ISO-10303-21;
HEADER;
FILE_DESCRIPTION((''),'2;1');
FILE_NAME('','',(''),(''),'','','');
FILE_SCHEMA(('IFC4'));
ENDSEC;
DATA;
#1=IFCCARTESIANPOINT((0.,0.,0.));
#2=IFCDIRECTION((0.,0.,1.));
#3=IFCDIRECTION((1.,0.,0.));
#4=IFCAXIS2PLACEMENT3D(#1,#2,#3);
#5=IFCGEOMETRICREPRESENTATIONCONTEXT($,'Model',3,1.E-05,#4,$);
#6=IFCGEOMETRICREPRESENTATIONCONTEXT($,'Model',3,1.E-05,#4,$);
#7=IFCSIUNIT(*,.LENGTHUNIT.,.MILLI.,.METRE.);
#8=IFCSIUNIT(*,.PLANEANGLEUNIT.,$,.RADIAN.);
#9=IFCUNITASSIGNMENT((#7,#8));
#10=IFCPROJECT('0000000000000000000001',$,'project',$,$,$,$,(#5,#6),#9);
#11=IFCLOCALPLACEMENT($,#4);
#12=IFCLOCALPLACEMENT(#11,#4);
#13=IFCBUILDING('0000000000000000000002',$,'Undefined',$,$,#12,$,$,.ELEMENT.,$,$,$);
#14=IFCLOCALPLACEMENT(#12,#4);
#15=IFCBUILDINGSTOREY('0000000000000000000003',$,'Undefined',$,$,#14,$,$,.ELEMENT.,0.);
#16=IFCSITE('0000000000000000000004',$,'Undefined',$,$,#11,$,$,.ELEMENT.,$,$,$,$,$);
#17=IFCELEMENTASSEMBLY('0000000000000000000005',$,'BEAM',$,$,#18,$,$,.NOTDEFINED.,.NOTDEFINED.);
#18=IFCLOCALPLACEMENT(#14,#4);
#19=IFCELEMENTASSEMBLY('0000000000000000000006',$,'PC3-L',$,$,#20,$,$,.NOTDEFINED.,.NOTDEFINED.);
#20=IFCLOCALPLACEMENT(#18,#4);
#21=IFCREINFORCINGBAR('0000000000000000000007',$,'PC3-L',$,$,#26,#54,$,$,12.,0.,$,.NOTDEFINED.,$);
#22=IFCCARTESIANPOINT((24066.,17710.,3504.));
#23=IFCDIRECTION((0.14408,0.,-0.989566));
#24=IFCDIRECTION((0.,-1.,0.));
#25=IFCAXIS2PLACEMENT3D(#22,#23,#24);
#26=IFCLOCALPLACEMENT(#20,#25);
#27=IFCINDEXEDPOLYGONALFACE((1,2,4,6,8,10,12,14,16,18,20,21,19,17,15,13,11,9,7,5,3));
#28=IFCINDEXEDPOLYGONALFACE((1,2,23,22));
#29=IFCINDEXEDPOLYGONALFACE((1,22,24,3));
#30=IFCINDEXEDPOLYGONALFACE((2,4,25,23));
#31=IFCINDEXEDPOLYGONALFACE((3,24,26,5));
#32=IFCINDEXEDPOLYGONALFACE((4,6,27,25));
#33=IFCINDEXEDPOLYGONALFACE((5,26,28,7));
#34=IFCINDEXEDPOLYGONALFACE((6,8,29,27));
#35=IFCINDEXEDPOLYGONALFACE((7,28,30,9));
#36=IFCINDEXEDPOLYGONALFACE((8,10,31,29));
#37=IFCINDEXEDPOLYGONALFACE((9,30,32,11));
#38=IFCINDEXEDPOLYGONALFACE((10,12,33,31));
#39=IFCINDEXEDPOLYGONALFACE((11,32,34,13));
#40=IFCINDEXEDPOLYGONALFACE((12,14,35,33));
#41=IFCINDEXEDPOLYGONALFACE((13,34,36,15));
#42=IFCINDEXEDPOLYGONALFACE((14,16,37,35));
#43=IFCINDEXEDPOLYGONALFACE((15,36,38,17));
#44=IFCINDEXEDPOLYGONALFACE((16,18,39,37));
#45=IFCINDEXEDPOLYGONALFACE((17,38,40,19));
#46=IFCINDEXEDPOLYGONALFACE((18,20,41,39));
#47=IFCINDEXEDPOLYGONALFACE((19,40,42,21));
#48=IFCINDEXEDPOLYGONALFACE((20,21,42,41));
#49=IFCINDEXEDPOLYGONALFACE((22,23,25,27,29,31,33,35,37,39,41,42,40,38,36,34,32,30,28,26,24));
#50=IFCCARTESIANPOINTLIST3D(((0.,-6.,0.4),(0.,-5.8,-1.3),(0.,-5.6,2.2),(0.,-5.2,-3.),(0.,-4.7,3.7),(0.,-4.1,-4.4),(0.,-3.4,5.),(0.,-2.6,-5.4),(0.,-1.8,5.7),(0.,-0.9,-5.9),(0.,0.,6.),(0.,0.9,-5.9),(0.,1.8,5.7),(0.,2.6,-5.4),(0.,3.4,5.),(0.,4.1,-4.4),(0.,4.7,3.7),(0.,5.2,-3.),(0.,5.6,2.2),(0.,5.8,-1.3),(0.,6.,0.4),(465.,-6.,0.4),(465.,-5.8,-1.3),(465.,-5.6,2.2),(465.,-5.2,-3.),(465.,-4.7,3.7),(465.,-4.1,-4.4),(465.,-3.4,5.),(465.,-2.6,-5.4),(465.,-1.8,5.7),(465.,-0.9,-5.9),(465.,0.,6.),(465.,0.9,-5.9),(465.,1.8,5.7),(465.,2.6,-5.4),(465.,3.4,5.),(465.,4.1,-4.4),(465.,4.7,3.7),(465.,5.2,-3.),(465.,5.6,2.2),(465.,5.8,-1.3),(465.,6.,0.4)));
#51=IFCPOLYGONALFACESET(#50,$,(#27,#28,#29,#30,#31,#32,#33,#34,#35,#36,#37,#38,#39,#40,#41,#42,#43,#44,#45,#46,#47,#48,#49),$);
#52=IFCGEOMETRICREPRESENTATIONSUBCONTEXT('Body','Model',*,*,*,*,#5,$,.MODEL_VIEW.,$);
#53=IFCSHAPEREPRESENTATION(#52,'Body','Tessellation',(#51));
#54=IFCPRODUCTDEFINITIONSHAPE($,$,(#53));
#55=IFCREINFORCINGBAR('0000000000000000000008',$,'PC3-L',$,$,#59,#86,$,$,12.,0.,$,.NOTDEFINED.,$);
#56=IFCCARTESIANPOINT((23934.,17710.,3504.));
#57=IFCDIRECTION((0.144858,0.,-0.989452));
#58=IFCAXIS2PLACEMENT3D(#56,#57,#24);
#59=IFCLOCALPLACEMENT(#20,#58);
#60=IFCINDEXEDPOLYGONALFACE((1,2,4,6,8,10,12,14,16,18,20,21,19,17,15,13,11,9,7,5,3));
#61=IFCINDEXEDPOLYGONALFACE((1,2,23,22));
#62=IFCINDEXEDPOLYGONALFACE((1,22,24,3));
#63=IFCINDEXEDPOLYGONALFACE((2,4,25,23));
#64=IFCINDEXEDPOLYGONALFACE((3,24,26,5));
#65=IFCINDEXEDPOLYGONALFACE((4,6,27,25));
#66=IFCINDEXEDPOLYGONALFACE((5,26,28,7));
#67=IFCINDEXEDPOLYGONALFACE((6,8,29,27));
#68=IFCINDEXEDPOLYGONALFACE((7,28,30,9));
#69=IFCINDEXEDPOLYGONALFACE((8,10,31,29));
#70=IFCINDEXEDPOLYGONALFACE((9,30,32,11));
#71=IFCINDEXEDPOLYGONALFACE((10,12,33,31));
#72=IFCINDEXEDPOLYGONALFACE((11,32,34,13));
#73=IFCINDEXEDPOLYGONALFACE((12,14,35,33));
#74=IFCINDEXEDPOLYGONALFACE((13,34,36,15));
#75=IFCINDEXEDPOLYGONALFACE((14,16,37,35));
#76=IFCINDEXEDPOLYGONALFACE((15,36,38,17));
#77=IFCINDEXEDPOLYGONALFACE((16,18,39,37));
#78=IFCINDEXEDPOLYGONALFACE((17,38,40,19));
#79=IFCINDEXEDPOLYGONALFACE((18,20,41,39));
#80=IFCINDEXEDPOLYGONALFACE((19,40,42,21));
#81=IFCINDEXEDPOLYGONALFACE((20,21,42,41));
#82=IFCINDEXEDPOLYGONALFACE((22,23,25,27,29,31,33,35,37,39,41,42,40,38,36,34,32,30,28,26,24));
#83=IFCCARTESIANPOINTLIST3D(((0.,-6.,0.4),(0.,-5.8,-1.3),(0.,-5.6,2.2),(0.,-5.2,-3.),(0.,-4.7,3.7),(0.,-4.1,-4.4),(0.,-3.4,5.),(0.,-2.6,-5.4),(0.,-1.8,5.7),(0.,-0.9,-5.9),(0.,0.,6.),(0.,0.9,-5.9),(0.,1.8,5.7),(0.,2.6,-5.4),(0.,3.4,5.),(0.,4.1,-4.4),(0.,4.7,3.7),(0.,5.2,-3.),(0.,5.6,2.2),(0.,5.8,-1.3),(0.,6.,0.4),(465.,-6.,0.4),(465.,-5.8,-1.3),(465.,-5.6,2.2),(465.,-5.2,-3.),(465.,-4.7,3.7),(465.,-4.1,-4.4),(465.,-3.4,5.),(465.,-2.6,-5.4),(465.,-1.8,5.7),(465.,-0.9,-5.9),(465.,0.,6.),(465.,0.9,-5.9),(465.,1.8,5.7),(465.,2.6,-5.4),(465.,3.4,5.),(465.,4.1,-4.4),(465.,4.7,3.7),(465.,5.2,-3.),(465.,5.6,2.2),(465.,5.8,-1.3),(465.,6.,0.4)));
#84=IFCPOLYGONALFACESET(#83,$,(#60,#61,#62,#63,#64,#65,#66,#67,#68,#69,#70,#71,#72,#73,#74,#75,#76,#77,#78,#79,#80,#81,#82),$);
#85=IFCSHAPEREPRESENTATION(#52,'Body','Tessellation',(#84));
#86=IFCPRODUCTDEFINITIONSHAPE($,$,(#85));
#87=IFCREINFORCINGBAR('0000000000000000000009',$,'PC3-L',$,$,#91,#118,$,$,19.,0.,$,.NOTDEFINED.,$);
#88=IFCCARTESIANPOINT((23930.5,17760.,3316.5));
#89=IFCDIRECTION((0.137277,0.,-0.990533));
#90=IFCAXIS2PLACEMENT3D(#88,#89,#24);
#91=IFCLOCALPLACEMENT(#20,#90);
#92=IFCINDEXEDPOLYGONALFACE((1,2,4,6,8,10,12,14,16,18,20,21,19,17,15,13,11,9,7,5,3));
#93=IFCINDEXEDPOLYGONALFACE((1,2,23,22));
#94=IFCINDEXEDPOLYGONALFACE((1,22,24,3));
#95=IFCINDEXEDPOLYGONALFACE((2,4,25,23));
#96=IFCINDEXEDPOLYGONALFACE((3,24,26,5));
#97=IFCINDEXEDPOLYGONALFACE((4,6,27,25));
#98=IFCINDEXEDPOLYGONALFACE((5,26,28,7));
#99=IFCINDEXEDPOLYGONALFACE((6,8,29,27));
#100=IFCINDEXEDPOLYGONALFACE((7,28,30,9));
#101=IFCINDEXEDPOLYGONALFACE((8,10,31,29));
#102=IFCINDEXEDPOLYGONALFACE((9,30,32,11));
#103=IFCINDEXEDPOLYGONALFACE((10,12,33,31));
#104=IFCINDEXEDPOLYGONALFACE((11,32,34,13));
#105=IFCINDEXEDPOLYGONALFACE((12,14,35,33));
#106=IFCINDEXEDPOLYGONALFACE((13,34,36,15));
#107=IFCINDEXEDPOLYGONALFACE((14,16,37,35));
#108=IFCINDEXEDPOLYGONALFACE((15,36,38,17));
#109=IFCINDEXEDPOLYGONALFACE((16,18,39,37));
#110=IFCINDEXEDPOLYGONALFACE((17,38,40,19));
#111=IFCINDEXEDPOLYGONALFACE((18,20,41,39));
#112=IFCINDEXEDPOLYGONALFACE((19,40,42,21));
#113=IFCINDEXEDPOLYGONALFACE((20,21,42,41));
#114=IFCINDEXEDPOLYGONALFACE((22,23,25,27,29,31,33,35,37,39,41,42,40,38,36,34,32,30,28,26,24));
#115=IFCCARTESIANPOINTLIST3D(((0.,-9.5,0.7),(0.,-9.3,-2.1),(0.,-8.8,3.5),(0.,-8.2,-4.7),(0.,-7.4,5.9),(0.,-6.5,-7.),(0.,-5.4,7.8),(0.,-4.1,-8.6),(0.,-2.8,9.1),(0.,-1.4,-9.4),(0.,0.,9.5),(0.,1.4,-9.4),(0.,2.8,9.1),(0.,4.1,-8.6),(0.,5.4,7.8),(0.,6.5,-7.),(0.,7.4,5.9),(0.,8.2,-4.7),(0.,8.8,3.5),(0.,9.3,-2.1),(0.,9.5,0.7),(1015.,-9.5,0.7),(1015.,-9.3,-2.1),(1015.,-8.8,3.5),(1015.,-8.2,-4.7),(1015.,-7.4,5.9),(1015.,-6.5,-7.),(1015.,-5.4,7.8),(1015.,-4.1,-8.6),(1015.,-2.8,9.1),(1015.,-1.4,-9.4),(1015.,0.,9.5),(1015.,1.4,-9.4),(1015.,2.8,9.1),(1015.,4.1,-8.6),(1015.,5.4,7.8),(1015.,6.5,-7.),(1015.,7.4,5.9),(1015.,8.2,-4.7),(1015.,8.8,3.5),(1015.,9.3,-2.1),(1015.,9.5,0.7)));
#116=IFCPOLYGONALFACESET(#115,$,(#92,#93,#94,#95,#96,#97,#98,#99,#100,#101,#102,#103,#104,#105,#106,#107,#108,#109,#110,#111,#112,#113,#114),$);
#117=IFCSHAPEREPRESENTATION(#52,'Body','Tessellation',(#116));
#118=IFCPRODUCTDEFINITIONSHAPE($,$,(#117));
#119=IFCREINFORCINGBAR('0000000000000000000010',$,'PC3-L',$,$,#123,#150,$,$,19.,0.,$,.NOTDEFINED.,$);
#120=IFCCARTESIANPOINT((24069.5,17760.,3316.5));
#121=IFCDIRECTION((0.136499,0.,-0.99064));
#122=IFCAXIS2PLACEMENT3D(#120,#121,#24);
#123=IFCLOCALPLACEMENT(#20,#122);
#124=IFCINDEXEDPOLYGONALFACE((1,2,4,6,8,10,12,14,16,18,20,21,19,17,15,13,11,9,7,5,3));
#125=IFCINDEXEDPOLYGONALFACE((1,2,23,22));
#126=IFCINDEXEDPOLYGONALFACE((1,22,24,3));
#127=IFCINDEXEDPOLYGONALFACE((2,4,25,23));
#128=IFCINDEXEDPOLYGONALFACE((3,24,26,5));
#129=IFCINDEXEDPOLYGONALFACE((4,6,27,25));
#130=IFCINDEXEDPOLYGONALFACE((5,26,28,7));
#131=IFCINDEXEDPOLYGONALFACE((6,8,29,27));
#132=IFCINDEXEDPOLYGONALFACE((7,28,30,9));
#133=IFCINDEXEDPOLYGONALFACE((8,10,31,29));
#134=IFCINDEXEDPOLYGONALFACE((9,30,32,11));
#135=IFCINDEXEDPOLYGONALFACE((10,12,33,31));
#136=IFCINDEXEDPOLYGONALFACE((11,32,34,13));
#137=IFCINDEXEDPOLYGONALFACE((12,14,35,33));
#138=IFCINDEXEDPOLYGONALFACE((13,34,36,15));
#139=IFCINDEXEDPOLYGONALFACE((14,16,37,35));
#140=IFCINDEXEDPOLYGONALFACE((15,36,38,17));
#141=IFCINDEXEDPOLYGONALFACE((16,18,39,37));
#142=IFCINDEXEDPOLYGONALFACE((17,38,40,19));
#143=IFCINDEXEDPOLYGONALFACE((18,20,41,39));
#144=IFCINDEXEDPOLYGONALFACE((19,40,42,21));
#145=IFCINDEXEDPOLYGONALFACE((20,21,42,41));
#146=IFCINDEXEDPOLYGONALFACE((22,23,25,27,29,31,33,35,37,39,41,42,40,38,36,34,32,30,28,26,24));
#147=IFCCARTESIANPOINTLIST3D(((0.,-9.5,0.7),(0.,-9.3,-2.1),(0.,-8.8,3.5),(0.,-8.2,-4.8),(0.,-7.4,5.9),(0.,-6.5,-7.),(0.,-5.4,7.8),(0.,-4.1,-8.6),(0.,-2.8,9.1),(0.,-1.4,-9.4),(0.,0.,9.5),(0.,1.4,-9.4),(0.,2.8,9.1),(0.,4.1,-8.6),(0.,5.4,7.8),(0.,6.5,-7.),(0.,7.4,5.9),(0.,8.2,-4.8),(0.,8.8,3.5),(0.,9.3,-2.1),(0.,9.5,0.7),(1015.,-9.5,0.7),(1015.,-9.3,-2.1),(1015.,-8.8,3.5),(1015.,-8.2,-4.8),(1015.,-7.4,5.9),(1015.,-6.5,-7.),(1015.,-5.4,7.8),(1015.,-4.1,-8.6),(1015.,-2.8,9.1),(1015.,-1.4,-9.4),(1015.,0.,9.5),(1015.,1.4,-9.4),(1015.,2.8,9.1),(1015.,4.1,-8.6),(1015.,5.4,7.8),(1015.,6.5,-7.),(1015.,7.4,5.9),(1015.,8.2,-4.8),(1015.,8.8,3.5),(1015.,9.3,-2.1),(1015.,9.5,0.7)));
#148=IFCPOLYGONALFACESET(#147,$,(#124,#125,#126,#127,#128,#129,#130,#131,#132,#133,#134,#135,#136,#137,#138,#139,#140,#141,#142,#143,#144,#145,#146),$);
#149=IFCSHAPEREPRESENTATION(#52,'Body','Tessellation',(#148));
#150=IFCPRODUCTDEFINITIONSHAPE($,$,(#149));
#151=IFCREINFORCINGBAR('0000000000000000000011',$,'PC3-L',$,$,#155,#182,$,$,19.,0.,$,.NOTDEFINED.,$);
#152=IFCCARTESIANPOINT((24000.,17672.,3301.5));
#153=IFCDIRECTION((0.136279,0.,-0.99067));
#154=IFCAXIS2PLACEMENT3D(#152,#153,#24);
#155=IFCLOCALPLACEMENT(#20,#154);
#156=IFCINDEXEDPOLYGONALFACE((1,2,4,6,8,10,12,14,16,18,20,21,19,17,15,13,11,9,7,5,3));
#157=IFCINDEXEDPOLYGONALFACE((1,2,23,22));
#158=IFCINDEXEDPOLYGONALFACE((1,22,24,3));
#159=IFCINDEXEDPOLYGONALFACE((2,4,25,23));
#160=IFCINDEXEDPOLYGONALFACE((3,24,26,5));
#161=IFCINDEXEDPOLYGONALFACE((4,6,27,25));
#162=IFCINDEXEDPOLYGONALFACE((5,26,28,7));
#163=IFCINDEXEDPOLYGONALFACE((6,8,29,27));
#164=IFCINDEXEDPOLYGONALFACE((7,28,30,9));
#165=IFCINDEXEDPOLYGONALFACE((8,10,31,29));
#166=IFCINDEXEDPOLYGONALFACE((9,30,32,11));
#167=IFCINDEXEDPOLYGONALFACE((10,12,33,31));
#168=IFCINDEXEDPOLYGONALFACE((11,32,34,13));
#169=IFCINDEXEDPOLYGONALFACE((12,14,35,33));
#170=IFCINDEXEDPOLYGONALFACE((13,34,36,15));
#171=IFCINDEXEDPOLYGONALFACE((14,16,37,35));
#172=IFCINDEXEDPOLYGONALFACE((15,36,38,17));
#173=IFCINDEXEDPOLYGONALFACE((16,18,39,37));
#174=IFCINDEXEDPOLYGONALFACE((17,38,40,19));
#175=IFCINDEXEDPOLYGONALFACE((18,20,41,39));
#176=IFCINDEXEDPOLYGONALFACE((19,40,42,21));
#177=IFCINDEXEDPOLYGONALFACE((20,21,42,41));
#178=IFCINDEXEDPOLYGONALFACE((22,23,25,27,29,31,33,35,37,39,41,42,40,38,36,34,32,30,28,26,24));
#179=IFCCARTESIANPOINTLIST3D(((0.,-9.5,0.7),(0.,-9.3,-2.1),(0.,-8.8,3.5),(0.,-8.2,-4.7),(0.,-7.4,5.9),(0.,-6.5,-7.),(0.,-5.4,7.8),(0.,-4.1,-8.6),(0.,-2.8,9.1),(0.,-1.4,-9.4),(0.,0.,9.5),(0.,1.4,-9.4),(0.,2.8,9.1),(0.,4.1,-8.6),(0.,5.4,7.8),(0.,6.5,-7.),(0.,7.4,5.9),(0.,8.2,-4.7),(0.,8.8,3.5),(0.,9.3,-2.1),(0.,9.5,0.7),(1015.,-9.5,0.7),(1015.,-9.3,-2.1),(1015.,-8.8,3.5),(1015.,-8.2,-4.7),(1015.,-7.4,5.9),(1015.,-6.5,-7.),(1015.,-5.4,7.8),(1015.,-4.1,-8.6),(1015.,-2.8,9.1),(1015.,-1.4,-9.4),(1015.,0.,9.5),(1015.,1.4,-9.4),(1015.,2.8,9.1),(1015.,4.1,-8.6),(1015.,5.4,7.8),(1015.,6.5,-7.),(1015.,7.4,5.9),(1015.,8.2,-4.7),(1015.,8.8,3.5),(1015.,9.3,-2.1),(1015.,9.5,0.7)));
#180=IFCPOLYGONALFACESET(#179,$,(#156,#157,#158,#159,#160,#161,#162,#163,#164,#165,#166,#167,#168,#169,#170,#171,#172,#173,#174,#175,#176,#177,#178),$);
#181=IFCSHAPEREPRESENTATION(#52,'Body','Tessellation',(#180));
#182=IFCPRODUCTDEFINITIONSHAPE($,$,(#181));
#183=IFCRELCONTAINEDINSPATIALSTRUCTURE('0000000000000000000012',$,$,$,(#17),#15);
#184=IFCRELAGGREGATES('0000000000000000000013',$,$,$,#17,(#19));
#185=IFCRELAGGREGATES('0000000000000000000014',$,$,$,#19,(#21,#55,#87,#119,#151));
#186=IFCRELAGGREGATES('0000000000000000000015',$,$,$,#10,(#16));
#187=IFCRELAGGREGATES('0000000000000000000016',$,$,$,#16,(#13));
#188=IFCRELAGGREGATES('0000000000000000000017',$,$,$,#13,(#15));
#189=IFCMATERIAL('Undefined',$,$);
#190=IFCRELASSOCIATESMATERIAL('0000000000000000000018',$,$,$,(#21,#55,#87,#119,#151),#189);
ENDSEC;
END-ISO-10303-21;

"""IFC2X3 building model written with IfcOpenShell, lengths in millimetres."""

from ifc_helpers import new_model, entity, si_unit, frame, origin_with_axes, place, context, subcontext, project, spatial, source, transform, mapped, material, element, aggregate, save


model = new_model("IFC2X3")

# Units and contexts
model_context_1 = context("Model", 3, precision=1e-05, world=origin_with_axes())
model_context_2 = context("Model", 3, precision=1e-05, world=origin_with_axes())
body_context = subcontext(model_context_1, "Body", "Model", "MODEL_VIEW")
ifc_project = project(units=[si_unit("LENGTHUNIT", "METRE", prefix="MILLI"), si_unit("PLANEANGLEUNIT", "RADIAN")], contexts=[model_context_1, model_context_2])

# Site, building, storey
site_placement = place(None, origin_with_axes())
site = spatial("IfcSite", under=ifc_project, at=site_placement, Name="Undefined", CompositionType="ELEMENT")
building_placement = place(site_placement, origin_with_axes())
building = spatial("IfcBuilding", under=site, at=building_placement, Name="Undefined", CompositionType="ELEMENT")
storey_placement = place(building_placement, origin_with_axes())
storey = spatial("IfcBuildingStorey", under=building, at=storey_placement, Name="Undefined", CompositionType="ELEMENT", Elevation=0.0)

# Element assemblies
assembly_1_placement = place(storey_placement, origin_with_axes())
assembly_1 = element("IfcElementAssembly", 1, at=assembly_1_placement, inside=storey, Name="BEAM", AssemblyPlace="NOTDEFINED", PredefinedType="NOTDEFINED")
assembly_2_placement = place(assembly_1_placement, origin_with_axes())
assembly_2 = element("IfcElementAssembly", 2, at=assembly_2_placement, Name="PC3-L", AssemblyPlace="NOTDEFINED", PredefinedType="NOTDEFINED")
aggregate(assembly_1, [assembly_2])

# Reinforcing bars
ifc_material_1 = material(Name="Undefined")
shared_shape_1 = source(origin_with_axes(), body_context, "Body", "AdvancedSweptSolid", [
    entity("IfcSweptDiskSolid", entity("IfcTrimmedCurve", entity("IfcLine", entity("IfcCartesianPoint", [0.0, 0.0, 0.0]), entity("IfcVector", entity("IfcDirection", [1.0, 0.0, 0.0]), 1.0)), [entity("IfcParameterValue", 0.0)], [entity("IfcParameterValue", 465.0)], True, "PARAMETER"), 6.0, None, 0.0, 465.0),
])
reinforcing_bar_1_placement = place(assembly_2_placement, frame((24066.0, 17710.0, 3504.0), z_axis=(0.14408, 0.0, -0.989566), x_axis=(0.0, -1.0, 0.0)))
reinforcing_bar_1 = element("IfcReinforcingBar", 3, at=reinforcing_bar_1_placement, material=ifc_material_1, Name="PC3-L", BarRole="NOTDEFINED", CrossSectionArea=0.0, NominalDiameter=12.0, context=body_context, shape_type="MappedRepresentation", body=[
    mapped(shared_shape_1, transform((0.0, 0.0, 0.0))),
])
shared_shape_2 = source(origin_with_axes(), body_context, "Body", "AdvancedSweptSolid", [
    entity("IfcSweptDiskSolid", entity("IfcTrimmedCurve", entity("IfcLine", entity("IfcCartesianPoint", [0.0, 0.0, 0.0]), entity("IfcVector", entity("IfcDirection", [1.0, 0.0, 0.0]), 1.0)), [entity("IfcParameterValue", 0.0)], [entity("IfcParameterValue", 465.0)], True, "PARAMETER"), 6.0, None, 0.0, 465.0),
])
reinforcing_bar_2_placement = place(assembly_2_placement, frame((23934.0, 17710.0, 3504.0), z_axis=(0.144858, 0.0, -0.989452), x_axis=(0.0, -1.0, 0.0)))
reinforcing_bar_2 = element("IfcReinforcingBar", 4, at=reinforcing_bar_2_placement, material=ifc_material_1, Name="PC3-L", BarRole="NOTDEFINED", CrossSectionArea=0.0, NominalDiameter=12.0, context=body_context, shape_type="MappedRepresentation", body=[
    mapped(shared_shape_2, transform((0.0, 0.0, 0.0))),
])
shared_shape_3 = source(origin_with_axes(), body_context, "Body", "AdvancedSweptSolid", [
    entity("IfcSweptDiskSolid", entity("IfcTrimmedCurve", entity("IfcLine", entity("IfcCartesianPoint", [0.0, 0.0, 0.0]), entity("IfcVector", entity("IfcDirection", [1.0, 0.0, 0.0]), 1.0)), [entity("IfcParameterValue", 0.0)], [entity("IfcParameterValue", 1015.0)], True, "PARAMETER"), 9.5, None, 0.0, 1015.0),
])
reinforcing_bar_3_placement = place(assembly_2_placement, frame((23930.5, 17760.0, 3316.5), z_axis=(0.137277, 0.0, -0.990533), x_axis=(0.0, -1.0, 0.0)))
reinforcing_bar_3 = element("IfcReinforcingBar", 5, at=reinforcing_bar_3_placement, material=ifc_material_1, Name="PC3-L", BarRole="NOTDEFINED", CrossSectionArea=0.0, NominalDiameter=19.0, context=body_context, shape_type="MappedRepresentation", body=[
    mapped(shared_shape_3, transform((0.0, 0.0, 0.0))),
])
shared_shape_4 = source(origin_with_axes(), body_context, "Body", "AdvancedSweptSolid", [
    entity("IfcSweptDiskSolid", entity("IfcTrimmedCurve", entity("IfcLine", entity("IfcCartesianPoint", [0.0, 0.0, 0.0]), entity("IfcVector", entity("IfcDirection", [1.0, 0.0, 0.0]), 1.0)), [entity("IfcParameterValue", 0.0)], [entity("IfcParameterValue", 1015.0)], True, "PARAMETER"), 9.5, None, 0.0, 1015.0),
])
reinforcing_bar_4_placement = place(assembly_2_placement, frame((24069.5, 17760.0, 3316.5), z_axis=(0.136499, 0.0, -0.99064), x_axis=(0.0, -1.0, 0.0)))
reinforcing_bar_4 = element("IfcReinforcingBar", 6, at=reinforcing_bar_4_placement, material=ifc_material_1, Name="PC3-L", BarRole="NOTDEFINED", CrossSectionArea=0.0, NominalDiameter=19.0, context=body_context, shape_type="MappedRepresentation", body=[
    mapped(shared_shape_4, transform((0.0, 0.0, 0.0))),
])
shared_shape_5 = source(origin_with_axes(), body_context, "Body", "AdvancedSweptSolid", [
    entity("IfcSweptDiskSolid", entity("IfcTrimmedCurve", entity("IfcLine", entity("IfcCartesianPoint", [0.0, 0.0, 0.0]), entity("IfcVector", entity("IfcDirection", [1.0, 0.0, 0.0]), 1.0)), [entity("IfcParameterValue", 0.0)], [entity("IfcParameterValue", 1015.0)], True, "PARAMETER"), 9.5, None, 0.0, 1015.0),
])
reinforcing_bar_5_placement = place(assembly_2_placement, frame((24000.0, 17672.0, 3301.5), z_axis=(0.136279, 0.0, -0.99067), x_axis=(0.0, -1.0, 0.0)))
reinforcing_bar_5 = element("IfcReinforcingBar", 7, at=reinforcing_bar_5_placement, material=ifc_material_1, Name="PC3-L", BarRole="NOTDEFINED", CrossSectionArea=0.0, NominalDiameter=19.0, context=body_context, shape_type="MappedRepresentation", body=[
    mapped(shared_shape_5, transform((0.0, 0.0, 0.0))),
])
aggregate(assembly_2, [reinforcing_bar_1, reinforcing_bar_2, reinforcing_bar_3, reinforcing_bar_4, reinforcing_bar_5])

save(model, "model.ifc")
